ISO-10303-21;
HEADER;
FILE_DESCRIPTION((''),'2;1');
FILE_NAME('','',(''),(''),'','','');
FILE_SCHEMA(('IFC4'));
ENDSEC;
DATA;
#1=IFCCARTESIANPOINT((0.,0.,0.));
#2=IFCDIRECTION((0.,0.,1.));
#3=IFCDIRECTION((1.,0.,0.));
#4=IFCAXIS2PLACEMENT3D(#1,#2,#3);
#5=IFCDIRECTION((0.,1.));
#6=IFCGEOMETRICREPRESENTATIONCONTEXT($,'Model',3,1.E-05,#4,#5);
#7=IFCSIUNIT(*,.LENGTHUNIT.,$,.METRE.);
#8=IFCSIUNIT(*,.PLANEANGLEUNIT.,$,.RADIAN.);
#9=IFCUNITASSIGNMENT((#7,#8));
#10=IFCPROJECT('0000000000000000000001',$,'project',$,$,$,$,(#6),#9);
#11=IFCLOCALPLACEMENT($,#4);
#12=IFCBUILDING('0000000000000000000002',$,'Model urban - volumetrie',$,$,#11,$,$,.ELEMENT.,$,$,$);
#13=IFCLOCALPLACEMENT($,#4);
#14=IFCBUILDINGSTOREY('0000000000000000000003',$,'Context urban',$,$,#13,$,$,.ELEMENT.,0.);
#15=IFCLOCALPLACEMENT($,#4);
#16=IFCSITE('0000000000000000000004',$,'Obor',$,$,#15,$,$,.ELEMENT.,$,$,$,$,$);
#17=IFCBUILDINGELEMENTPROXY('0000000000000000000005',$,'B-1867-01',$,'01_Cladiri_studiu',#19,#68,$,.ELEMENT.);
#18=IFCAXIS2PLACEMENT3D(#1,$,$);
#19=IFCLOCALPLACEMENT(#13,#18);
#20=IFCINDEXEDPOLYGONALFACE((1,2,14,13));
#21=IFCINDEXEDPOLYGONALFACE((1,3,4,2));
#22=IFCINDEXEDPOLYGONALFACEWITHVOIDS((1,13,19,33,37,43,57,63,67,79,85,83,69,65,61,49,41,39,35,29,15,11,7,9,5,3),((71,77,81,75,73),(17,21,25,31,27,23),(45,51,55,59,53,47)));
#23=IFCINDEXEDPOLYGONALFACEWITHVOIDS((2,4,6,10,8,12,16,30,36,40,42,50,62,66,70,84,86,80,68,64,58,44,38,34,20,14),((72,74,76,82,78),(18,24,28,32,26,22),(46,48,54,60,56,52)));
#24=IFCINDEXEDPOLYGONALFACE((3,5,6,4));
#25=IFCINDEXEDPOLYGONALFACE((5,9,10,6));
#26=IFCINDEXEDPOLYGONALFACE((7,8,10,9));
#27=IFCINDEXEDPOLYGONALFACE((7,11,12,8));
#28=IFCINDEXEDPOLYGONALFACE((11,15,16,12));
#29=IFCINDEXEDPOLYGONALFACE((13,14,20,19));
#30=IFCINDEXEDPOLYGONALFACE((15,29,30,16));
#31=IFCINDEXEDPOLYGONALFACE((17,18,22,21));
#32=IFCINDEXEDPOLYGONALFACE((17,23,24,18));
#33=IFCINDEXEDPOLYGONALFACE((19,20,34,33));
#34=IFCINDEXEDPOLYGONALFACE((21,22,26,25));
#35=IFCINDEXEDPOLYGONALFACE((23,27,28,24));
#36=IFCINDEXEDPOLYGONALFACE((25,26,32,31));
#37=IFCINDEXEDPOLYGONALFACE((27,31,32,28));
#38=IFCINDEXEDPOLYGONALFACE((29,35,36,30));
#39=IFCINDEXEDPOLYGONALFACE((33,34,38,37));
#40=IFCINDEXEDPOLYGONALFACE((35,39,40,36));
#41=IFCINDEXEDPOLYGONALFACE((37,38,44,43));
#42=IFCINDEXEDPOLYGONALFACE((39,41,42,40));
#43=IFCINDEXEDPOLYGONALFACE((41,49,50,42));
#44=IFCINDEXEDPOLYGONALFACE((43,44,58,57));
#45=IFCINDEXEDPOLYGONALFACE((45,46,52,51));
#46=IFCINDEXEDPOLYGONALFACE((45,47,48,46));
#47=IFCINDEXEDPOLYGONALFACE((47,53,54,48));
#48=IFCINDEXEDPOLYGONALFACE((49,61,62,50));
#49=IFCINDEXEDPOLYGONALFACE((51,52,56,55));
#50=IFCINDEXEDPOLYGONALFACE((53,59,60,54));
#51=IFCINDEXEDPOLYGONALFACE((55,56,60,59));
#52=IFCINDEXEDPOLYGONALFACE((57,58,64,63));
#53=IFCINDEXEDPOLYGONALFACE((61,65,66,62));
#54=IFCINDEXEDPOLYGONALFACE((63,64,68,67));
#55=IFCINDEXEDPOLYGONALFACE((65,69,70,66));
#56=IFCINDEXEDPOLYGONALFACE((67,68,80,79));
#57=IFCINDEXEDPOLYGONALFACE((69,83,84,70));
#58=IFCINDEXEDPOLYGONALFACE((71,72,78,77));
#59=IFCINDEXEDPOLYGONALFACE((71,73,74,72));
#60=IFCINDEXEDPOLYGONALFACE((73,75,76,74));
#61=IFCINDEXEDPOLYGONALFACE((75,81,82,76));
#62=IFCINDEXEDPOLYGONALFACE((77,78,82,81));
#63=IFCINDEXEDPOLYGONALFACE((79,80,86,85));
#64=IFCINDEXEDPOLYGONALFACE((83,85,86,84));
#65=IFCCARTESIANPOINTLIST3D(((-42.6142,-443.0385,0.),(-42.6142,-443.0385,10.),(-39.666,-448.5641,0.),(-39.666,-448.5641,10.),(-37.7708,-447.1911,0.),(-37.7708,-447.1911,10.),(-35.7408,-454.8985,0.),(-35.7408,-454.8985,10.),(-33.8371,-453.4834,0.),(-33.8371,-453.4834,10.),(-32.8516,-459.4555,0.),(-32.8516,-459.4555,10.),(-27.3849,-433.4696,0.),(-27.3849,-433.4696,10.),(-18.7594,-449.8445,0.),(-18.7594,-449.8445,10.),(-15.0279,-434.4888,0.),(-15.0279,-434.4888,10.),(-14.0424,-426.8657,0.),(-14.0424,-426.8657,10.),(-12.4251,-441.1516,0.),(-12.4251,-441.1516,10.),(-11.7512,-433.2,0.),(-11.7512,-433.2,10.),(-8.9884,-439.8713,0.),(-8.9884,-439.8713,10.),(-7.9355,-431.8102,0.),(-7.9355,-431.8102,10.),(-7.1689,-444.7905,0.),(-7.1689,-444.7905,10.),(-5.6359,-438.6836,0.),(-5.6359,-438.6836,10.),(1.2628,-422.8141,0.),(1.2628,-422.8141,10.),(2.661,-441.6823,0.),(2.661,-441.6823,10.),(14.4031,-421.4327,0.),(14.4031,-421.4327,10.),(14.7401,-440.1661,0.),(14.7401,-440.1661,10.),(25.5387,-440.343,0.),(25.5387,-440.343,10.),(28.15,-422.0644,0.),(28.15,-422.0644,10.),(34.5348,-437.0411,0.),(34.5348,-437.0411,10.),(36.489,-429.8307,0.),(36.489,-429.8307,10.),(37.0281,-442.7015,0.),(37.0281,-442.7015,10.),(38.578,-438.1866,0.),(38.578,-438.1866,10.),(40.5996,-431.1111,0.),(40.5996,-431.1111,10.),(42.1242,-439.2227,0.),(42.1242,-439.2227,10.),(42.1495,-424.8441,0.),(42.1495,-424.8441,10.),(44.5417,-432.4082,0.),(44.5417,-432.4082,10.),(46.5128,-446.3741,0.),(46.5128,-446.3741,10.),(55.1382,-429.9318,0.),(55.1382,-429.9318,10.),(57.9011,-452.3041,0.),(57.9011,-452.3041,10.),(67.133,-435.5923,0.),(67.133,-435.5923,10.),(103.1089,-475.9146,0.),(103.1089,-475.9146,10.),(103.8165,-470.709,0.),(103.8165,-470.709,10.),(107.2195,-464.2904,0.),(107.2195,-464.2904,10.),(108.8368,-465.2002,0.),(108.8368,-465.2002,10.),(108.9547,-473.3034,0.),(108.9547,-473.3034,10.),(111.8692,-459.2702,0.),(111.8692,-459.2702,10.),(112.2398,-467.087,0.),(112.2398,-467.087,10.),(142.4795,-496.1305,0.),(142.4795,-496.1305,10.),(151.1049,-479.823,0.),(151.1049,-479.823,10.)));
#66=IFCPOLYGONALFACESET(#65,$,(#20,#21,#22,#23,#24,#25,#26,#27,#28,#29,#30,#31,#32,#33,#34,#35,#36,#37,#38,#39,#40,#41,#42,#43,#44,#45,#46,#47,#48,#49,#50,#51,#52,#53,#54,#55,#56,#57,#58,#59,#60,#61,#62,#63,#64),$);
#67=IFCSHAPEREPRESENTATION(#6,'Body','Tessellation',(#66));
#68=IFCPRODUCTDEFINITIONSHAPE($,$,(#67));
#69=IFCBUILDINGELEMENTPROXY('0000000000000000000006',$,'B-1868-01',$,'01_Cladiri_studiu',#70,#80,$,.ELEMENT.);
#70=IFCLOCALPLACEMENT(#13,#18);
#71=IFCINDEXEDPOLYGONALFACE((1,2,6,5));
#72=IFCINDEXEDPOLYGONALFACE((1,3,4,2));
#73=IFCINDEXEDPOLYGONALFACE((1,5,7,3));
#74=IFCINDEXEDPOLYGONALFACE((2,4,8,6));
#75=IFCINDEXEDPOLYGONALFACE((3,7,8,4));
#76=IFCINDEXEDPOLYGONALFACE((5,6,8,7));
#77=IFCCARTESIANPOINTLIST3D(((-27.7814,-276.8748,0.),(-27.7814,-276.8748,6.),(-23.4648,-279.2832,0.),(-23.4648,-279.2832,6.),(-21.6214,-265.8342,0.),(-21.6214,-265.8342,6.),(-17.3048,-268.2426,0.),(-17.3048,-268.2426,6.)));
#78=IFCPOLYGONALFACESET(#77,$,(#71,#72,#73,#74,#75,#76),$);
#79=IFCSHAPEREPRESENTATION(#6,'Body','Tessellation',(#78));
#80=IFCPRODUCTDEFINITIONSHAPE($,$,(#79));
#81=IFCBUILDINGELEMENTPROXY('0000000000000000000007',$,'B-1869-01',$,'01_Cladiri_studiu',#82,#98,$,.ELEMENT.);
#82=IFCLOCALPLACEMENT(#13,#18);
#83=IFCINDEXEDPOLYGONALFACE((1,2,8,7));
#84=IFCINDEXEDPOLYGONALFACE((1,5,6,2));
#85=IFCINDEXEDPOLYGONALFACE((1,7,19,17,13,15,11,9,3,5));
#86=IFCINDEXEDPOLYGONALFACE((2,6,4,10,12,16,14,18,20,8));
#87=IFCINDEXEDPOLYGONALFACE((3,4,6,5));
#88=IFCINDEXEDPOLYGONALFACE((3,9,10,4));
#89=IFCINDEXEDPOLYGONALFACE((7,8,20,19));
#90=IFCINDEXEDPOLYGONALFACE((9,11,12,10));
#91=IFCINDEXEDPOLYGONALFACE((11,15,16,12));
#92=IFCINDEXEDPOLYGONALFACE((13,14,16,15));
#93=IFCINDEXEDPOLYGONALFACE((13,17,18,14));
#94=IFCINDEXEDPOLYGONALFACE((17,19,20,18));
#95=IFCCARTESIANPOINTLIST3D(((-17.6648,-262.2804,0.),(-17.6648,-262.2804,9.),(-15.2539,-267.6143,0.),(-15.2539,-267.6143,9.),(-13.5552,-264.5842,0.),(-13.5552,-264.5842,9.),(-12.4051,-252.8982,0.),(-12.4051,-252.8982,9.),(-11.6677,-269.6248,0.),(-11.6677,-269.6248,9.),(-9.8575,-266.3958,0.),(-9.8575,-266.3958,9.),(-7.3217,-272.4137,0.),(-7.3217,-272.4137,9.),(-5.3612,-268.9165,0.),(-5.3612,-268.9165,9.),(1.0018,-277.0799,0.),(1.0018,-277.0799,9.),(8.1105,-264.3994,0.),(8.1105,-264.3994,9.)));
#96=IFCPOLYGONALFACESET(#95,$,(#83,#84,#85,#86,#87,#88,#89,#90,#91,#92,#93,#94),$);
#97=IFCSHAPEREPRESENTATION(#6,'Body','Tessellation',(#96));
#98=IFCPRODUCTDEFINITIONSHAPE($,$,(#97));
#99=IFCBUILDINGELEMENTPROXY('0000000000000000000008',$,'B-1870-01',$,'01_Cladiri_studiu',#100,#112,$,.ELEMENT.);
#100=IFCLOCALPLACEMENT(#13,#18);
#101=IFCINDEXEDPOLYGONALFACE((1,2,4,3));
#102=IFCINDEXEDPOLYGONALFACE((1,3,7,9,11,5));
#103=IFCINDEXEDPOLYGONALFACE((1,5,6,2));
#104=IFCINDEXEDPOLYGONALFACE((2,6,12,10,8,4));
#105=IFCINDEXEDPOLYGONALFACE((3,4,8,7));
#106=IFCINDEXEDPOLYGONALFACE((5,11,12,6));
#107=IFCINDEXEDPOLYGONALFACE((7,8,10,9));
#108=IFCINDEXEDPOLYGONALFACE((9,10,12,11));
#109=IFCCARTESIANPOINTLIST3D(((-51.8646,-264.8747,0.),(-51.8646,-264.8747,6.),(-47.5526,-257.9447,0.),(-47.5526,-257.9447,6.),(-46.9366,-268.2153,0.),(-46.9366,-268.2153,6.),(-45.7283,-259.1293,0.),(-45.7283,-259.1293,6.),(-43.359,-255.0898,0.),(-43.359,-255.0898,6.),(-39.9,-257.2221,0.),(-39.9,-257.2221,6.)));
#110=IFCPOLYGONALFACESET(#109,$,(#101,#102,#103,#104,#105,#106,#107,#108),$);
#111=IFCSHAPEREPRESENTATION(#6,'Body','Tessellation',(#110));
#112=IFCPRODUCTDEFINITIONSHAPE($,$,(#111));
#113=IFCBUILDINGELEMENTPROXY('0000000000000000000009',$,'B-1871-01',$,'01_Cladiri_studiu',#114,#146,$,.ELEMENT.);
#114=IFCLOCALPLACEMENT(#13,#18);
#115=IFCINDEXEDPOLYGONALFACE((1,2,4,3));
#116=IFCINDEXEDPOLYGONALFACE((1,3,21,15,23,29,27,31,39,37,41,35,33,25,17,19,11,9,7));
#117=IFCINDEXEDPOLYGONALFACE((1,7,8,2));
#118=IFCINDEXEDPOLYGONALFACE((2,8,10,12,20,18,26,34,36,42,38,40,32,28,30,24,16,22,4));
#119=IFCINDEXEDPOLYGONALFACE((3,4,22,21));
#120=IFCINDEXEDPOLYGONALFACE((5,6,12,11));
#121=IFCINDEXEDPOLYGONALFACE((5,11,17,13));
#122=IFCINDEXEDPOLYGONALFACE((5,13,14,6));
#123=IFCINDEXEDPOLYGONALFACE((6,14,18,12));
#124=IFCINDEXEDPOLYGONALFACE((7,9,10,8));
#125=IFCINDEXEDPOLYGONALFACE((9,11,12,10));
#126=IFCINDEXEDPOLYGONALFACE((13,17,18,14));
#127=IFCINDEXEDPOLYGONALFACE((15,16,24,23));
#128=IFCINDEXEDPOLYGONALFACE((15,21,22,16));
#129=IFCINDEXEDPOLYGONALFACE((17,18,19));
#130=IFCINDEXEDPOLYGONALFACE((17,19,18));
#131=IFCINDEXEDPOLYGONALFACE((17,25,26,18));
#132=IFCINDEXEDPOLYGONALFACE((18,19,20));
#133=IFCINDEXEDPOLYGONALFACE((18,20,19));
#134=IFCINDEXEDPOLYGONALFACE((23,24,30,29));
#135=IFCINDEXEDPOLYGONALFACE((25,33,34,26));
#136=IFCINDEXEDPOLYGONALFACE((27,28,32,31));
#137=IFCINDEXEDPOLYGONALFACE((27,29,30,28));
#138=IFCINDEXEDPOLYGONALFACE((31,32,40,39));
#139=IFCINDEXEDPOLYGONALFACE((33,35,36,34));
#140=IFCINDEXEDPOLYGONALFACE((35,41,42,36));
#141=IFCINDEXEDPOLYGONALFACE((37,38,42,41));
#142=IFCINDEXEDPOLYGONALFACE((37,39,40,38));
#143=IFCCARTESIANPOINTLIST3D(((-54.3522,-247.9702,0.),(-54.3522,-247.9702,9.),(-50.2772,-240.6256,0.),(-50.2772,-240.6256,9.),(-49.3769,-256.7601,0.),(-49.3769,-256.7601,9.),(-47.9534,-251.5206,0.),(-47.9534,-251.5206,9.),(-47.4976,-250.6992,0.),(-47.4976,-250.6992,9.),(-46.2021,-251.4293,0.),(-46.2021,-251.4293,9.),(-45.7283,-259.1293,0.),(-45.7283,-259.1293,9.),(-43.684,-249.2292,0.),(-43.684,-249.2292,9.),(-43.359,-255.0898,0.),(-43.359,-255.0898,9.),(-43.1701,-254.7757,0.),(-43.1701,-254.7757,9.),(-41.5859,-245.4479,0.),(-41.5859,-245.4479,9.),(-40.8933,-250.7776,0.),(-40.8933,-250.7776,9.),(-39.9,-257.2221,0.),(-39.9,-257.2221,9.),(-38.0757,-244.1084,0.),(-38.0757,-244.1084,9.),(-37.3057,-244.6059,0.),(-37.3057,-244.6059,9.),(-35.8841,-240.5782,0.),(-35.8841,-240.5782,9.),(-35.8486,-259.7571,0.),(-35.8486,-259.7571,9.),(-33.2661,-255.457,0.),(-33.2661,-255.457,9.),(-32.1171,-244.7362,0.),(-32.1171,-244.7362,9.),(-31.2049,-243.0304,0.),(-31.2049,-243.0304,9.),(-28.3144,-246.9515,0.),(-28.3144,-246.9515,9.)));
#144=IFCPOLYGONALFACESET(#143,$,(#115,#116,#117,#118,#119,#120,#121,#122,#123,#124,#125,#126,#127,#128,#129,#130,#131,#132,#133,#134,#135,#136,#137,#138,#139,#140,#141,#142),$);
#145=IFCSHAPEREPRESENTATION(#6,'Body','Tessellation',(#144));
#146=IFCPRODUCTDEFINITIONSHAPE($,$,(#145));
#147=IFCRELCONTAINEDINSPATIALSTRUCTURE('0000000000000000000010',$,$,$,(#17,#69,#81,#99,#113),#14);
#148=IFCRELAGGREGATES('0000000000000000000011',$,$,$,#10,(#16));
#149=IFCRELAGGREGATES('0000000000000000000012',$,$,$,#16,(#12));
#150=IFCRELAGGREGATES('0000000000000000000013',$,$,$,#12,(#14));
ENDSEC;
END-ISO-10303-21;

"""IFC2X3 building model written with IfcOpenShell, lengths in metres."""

from ifc_helpers import new_model, si_unit, direction, origin_with_axes, place, context, project, spatial, polyline, outline, extrude, element, save


model = new_model("IFC2X3")

# Units and contexts
model_context = context("Model", 3, precision=1e-05, world=origin_with_axes(), true_north=direction((0.0, 1.0)))
ifc_project = project(units=[si_unit("LENGTHUNIT", "METRE"), si_unit("PLANEANGLEUNIT", "RADIAN")], contexts=[model_context])

# Site, building, storey
site_placement = place(None, origin_with_axes())
site = spatial("IfcSite", under=ifc_project, at=site_placement, Name="Obor", CompositionType="ELEMENT")
building_placement = place(None, origin_with_axes())
building = spatial("IfcBuilding", under=site, at=building_placement, Name="Model urban - volumetrie", CompositionType="ELEMENT")
storey_placement = place(None, origin_with_axes())
storey = spatial("IfcBuildingStorey", under=building, at=storey_placement, Name="Context urban", CompositionType="ELEMENT", Elevation=0.0)

# Building element proxies
proxy_1_placement = place(None, origin_with_axes())
element("IfcBuildingElementProxy", 1, at=proxy_1_placement, inside=storey, Name="B-1867-01", ObjectType="01_Cladiri_studiu", CompositionType="ELEMENT", context=model_context, shape_type="SweptSolid", body=[
    extrude(outline(polyline([(-39.666, -448.5641), (-37.7708, -447.1911), (-33.8371, -453.4834), (-35.7408, -454.8985), (-32.8516, -459.4555), (-18.7594, -449.8445), (-7.1689, -444.7905), (2.661, -441.6823), (14.7401, -440.1661), (25.5387, -440.343), (37.0281, -442.7015), (46.5128, -446.3741), (57.9011, -452.3041), (103.1089, -475.9146), (142.4795, -496.1305), (151.1049, -479.823), (111.8692, -459.2702), (67.133, -435.5923), (55.1382, -429.9318), (42.1495, -424.8441), (28.15, -422.0644), (14.4031, -421.4327), (1.2628, -422.8141), (-14.0424, -426.8657), (-27.3849, -433.4696), (-42.6142, -443.0385), (-39.666, -448.5641)]), holes=[polyline([(-7.9355, -431.8102), (-5.6359, -438.6836), (-8.9884, -439.8713), (-12.4251, -441.1516), (-15.0279, -434.4888), (-11.7512, -433.2), (-7.9355, -431.8102)]), polyline([(112.2398, -467.087), (108.9547, -473.3034), (103.8165, -470.709), (107.2195, -464.2904), (108.8368, -465.2002), (112.2398, -467.087)]), polyline([(38.578, -438.1866), (34.5348, -437.0411), (36.489, -429.8307), (40.5996, -431.1111), (44.5417, -432.4082), (42.1242, -439.2227), (38.578, -438.1866)])]), origin_with_axes(), (0.0, 0.0, 1.0), 10.0),
])
proxy_2_placement = place(None, origin_with_axes())
element("IfcBuildingElementProxy", 2, at=proxy_2_placement, inside=storey, Name="B-1868-01", ObjectType="01_Cladiri_studiu", CompositionType="ELEMENT", context=model_context, shape_type="SweptSolid", body=[
    extrude(outline(polyline([(-23.4648, -279.2832), (-17.3048, -268.2426), (-21.6214, -265.8342), (-27.7814, -276.8748), (-23.4648, -279.2832)])), origin_with_axes(), (0.0, 0.0, 1.0), 6.0),
])
proxy_3_placement = place(None, origin_with_axes())
element("IfcBuildingElementProxy", 3, at=proxy_3_placement, inside=storey, Name="B-1869-01", ObjectType="01_Cladiri_studiu", CompositionType="ELEMENT", context=model_context, shape_type="SweptSolid", body=[
    extrude(outline(polyline([(-7.3217, -272.4137), (1.0018, -277.0799), (8.1105, -264.3994), (-12.4051, -252.8982), (-17.6648, -262.2804), (-13.5552, -264.5842), (-15.2539, -267.6143), (-11.6677, -269.6248), (-9.8575, -266.3958), (-5.3612, -268.9165), (-7.3217, -272.4137)])), origin_with_axes(), (0.0, 0.0, 1.0), 9.0),
])
proxy_4_placement = place(None, origin_with_axes())
element("IfcBuildingElementProxy", 4, at=proxy_4_placement, inside=storey, Name="B-1870-01", ObjectType="01_Cladiri_studiu", CompositionType="ELEMENT", context=model_context, shape_type="SweptSolid", body=[
    extrude(outline(polyline([(-43.359, -255.0898), (-45.7283, -259.1293), (-47.5526, -257.9447), (-51.8646, -264.8747), (-46.9366, -268.2153), (-39.9, -257.2221), (-43.359, -255.0898)])), origin_with_axes(), (0.0, 0.0, 1.0), 6.0),
])
proxy_5_placement = place(None, origin_with_axes())
element("IfcBuildingElementProxy", 5, at=proxy_5_placement, inside=storey, Name="B-1871-01", ObjectType="01_Cladiri_studiu", CompositionType="ELEMENT", context=model_context, shape_type="SweptSolid", body=[
    extrude(outline(polyline([(-43.1701, -254.7757), (-43.359, -255.0898), (-39.9, -257.2221), (-35.8486, -259.7571), (-33.2661, -255.457), (-28.3144, -246.9515), (-32.1171, -244.7362), (-31.2049, -243.0304), (-35.8841, -240.5782), (-38.0757, -244.1084), (-37.3057, -244.6059), (-40.8933, -250.7776), (-43.684, -249.2292), (-41.5859, -245.4479), (-50.2772, -240.6256), (-54.3522, -247.9702), (-47.9534, -251.5206), (-47.4976, -250.6992), (-46.2021, -251.4293), (-49.3769, -256.7601), (-45.7283, -259.1293), (-43.359, -255.0898), (-43.1701, -254.7757)])), origin_with_axes(), (0.0, 0.0, 1.0), 9.0),
])

save(model, "model.ifc")
